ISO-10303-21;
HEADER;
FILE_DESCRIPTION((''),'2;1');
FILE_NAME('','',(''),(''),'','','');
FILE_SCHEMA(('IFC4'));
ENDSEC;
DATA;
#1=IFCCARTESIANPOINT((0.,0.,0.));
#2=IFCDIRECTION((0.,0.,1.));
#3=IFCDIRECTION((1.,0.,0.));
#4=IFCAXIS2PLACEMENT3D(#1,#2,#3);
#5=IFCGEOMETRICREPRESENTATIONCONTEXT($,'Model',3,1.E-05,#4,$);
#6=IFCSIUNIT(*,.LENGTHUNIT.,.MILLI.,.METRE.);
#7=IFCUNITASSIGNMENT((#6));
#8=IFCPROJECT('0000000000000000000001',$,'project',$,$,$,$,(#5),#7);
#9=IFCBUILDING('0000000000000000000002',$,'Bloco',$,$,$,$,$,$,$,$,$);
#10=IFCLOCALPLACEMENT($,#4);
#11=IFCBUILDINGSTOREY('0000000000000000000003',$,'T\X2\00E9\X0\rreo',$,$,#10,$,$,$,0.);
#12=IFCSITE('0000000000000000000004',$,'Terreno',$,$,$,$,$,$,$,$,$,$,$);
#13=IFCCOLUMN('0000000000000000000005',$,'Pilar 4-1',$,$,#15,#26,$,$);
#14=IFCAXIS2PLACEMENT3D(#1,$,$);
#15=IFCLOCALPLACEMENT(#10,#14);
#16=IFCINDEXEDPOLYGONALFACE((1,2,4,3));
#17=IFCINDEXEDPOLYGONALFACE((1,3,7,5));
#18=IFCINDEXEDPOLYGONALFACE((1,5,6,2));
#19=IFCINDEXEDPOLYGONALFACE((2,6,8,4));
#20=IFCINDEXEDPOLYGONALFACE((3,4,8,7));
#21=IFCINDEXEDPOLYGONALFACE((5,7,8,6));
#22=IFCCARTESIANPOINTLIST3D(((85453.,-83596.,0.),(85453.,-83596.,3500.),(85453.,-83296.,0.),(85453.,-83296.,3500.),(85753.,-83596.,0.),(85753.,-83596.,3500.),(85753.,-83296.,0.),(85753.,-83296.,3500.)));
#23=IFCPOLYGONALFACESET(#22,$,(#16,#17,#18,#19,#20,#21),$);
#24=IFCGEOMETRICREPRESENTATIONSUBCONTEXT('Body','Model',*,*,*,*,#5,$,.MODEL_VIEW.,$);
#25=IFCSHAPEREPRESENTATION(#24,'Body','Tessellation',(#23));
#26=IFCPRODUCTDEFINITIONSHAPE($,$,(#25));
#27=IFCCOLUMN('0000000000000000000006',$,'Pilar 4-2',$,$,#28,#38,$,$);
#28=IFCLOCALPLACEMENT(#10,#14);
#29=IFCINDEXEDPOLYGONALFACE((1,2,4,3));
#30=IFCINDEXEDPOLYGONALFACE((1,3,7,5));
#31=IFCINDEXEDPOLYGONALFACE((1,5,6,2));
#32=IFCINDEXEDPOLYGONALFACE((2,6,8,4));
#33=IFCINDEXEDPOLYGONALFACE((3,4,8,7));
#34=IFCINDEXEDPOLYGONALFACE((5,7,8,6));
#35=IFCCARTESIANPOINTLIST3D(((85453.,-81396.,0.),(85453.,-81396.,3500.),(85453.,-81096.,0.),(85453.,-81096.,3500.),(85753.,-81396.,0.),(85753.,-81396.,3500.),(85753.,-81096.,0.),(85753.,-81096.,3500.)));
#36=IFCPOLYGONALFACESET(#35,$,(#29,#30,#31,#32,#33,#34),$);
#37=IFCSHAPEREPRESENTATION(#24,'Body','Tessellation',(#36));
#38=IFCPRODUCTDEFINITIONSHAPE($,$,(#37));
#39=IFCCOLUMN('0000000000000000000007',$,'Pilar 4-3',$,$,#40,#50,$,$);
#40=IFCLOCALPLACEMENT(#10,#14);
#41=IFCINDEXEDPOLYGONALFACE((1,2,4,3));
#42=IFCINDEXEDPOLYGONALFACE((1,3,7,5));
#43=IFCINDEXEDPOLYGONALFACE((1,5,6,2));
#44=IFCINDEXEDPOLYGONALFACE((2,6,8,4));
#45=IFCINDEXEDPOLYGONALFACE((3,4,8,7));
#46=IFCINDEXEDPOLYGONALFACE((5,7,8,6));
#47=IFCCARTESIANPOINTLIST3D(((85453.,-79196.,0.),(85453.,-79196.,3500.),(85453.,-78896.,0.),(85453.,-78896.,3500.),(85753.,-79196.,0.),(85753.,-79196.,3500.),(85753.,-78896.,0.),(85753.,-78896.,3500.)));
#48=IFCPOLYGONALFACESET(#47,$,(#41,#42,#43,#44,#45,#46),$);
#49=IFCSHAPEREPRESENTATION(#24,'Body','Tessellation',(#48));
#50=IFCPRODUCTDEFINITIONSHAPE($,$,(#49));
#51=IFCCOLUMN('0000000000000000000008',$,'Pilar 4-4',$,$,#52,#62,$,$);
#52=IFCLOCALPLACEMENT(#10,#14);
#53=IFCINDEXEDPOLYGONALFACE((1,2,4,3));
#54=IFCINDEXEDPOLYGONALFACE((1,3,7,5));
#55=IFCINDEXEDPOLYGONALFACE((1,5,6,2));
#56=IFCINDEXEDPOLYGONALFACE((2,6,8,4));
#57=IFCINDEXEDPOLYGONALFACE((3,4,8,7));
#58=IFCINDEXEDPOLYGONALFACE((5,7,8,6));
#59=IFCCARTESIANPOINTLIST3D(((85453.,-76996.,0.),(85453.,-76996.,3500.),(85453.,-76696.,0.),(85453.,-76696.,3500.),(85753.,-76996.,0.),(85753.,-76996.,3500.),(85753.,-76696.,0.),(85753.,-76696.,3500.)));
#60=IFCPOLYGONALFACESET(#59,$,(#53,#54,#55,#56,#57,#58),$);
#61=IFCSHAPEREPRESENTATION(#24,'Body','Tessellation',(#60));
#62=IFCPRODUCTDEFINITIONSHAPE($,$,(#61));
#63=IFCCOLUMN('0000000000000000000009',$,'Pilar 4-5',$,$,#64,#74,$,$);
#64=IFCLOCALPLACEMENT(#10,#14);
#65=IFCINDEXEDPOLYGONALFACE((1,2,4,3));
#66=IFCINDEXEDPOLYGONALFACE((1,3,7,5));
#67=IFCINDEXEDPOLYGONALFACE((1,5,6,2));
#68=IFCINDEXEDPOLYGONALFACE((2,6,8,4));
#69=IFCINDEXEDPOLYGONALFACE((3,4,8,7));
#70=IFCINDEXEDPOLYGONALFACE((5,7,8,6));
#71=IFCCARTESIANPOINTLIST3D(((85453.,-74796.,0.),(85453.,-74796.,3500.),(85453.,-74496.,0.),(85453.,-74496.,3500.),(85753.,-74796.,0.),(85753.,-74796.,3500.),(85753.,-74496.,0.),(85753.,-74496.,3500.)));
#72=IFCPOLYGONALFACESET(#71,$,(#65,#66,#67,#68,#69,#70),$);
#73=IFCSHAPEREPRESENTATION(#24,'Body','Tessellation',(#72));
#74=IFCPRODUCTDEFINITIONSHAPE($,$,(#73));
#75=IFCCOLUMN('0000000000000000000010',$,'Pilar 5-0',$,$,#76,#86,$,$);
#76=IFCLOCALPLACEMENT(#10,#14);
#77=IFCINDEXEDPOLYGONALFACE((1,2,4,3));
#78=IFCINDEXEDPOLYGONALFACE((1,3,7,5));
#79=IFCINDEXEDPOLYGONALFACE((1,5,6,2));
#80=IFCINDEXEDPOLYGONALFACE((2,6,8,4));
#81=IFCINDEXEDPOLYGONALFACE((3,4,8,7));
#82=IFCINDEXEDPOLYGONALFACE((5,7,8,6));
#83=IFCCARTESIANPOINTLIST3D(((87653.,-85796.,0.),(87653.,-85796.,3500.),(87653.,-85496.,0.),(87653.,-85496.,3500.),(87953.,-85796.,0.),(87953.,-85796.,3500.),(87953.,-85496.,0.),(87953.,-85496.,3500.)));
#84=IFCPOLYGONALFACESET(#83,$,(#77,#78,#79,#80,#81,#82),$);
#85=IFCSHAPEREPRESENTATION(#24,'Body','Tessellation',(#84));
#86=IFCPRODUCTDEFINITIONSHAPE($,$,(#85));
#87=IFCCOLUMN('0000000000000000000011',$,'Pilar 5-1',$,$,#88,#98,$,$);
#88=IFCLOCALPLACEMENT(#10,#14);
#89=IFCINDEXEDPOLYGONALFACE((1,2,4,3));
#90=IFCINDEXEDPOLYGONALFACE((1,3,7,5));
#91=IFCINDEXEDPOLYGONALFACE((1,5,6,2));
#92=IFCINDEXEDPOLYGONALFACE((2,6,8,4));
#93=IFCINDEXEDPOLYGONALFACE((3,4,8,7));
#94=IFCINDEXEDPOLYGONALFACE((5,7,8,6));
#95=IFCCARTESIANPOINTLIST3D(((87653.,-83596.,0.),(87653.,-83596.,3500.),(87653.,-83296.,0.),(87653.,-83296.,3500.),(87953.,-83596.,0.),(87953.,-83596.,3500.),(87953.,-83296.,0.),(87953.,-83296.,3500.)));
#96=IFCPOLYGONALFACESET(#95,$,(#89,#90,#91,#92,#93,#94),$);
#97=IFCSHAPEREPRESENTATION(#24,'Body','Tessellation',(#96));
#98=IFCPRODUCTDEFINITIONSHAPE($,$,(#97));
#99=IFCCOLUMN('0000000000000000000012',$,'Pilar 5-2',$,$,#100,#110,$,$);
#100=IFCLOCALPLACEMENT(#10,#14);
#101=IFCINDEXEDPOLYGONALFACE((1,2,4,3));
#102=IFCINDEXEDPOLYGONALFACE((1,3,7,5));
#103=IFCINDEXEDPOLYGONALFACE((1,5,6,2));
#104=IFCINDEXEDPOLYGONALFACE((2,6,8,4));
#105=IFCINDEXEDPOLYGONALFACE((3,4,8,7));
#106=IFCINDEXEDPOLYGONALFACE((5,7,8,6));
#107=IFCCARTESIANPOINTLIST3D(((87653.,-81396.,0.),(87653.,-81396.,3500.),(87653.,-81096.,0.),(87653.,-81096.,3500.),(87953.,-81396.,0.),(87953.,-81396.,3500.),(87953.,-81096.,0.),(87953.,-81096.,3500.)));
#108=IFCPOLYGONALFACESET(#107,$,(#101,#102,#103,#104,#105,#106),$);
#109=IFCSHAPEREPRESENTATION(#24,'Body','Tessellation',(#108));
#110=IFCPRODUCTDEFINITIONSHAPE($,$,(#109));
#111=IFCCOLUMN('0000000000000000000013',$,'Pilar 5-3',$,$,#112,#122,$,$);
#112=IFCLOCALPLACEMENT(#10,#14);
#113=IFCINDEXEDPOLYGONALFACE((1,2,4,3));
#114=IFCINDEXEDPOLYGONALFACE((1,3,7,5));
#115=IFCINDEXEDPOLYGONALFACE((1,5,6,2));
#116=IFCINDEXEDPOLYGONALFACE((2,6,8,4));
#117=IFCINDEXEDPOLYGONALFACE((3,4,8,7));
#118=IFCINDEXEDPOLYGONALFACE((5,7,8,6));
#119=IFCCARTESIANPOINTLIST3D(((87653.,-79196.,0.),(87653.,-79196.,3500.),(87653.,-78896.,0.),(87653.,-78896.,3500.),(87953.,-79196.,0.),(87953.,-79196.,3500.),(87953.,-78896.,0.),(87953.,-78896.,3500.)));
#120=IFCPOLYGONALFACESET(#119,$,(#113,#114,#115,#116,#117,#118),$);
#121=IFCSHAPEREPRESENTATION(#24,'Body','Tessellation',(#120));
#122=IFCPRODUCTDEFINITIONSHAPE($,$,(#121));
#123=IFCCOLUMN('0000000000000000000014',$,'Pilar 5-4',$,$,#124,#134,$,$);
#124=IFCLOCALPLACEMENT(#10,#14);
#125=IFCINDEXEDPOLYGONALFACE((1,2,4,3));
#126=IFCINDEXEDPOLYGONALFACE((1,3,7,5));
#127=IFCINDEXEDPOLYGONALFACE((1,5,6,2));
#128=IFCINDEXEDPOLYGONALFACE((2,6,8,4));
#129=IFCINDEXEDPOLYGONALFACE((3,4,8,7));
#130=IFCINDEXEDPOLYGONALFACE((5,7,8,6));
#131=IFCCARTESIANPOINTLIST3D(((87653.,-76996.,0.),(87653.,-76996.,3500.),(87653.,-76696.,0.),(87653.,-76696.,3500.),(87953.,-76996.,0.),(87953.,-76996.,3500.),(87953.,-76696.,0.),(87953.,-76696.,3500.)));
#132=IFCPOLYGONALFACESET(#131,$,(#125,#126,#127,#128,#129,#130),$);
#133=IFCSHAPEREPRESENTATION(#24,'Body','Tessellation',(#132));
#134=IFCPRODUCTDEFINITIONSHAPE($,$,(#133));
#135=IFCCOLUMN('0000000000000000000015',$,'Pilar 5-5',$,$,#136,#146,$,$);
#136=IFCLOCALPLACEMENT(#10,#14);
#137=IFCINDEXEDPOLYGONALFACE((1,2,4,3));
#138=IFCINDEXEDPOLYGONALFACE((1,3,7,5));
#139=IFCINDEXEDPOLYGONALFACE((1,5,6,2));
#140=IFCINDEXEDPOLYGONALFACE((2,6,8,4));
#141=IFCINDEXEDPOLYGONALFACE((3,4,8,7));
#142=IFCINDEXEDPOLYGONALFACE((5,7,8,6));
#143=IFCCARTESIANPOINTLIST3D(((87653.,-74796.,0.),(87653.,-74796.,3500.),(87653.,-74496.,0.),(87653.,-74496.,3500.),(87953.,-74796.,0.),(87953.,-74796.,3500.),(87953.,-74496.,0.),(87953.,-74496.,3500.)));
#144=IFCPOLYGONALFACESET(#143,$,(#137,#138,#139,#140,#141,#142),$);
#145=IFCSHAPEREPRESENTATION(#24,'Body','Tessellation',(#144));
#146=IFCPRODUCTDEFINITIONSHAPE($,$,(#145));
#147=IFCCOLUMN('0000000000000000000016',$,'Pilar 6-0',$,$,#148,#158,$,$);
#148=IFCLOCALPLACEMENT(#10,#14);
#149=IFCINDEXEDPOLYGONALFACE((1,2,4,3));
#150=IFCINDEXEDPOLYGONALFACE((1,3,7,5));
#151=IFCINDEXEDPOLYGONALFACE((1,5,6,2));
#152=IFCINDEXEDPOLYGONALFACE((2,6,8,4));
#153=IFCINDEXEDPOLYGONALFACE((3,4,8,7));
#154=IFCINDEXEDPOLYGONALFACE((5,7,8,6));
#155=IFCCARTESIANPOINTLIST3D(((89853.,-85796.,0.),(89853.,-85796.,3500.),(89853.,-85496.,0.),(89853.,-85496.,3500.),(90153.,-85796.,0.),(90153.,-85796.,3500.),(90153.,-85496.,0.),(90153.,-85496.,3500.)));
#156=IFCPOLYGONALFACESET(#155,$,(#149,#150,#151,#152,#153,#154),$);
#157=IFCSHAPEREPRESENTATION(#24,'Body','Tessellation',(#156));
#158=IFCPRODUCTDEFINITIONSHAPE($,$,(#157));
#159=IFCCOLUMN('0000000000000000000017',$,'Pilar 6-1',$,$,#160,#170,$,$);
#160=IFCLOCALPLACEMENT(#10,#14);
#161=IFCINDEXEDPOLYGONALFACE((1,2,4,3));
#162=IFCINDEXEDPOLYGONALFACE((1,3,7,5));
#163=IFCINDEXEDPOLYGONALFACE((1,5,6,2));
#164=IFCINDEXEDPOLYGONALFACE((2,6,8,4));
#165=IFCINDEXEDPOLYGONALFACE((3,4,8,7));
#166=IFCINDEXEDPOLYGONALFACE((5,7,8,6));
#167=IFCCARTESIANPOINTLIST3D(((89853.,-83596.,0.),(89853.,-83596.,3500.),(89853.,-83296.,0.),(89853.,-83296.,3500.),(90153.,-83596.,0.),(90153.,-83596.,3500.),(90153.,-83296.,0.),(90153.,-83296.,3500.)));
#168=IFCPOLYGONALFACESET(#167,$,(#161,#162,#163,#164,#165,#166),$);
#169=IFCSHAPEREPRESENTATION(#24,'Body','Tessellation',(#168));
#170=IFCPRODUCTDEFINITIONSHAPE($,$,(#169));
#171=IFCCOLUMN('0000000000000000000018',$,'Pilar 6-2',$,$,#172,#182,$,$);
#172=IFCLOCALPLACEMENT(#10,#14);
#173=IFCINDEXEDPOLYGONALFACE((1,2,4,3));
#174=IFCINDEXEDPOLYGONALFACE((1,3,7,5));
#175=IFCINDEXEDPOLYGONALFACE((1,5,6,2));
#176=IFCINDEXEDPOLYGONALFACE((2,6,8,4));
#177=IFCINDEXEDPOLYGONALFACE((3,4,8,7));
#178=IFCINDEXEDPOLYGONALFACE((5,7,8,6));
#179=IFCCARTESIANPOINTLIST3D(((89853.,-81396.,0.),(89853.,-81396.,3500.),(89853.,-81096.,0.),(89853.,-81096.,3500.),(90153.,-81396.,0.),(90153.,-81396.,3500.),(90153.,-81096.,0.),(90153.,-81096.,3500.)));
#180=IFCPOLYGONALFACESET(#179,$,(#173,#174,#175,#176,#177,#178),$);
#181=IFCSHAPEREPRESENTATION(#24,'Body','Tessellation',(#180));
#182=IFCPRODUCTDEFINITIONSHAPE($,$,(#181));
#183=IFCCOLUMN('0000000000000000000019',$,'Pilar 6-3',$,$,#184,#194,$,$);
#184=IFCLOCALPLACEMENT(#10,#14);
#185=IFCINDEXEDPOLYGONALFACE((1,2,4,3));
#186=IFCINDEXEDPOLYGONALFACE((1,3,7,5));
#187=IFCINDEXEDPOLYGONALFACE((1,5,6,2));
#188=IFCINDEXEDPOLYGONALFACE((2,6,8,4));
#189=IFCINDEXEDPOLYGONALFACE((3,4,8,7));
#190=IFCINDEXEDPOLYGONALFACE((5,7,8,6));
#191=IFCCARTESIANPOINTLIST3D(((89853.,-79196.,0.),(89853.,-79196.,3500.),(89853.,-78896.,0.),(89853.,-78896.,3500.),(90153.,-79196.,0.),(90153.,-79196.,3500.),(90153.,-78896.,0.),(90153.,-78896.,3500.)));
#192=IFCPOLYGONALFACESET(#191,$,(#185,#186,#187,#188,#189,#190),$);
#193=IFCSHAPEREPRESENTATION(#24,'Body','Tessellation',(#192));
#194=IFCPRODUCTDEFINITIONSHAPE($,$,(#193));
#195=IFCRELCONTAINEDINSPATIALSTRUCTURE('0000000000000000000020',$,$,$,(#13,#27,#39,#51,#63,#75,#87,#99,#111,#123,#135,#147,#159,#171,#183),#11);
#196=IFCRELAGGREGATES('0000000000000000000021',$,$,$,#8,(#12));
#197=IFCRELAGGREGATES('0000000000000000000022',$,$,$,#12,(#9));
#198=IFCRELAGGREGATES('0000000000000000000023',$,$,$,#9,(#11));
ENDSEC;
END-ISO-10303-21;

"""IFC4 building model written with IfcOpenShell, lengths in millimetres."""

from ifc_helpers import new_model, si_unit, origin, origin_with_axes, place, context, subcontext, project, spatial, polyline, outline, extrude, element, save


model = new_model("IFC4")

# Units and contexts
model_context = context("Model", 3, precision=1e-05, world=origin_with_axes())
body_context = subcontext(model_context, "Body", "Model", "MODEL_VIEW")
ifc_project = project(units=[si_unit("LENGTHUNIT", "METRE", prefix="MILLI")], contexts=[model_context])

# Site, building, storey
site = spatial("IfcSite", under=ifc_project, Name="Terreno")
building = spatial("IfcBuilding", under=site, Name="Bloco")
storey_placement = place(None, origin_with_axes())
storey = spatial("IfcBuildingStorey", under=building, at=storey_placement, Name="Térreo", Elevation=0.0)

# Columns
column_1_placement = place(storey_placement, origin_with_axes())
element("IfcColumn", 1, at=column_1_placement, inside=storey, Name="Pilar 4-1", context=body_context, shape_type="SweptSolid", body=[
    extrude(outline(polyline([(85453.0, -83596.0), (85753.0, -83596.0), (85753.0, -83296.0), (85453.0, -83296.0), (85453.0, -83596.0)])), origin(), (0.0, 0.0, 1.0), 3500.0),
])
column_2_placement = place(storey_placement, origin_with_axes())
element("IfcColumn", 2, at=column_2_placement, inside=storey, Name="Pilar 4-2", context=body_context, shape_type="SweptSolid", body=[
    extrude(outline(polyline([(85453.0, -81396.0), (85753.0, -81396.0), (85753.0, -81096.0), (85453.0, -81096.0), (85453.0, -81396.0)])), origin(), (0.0, 0.0, 1.0), 3500.0),
])
column_3_placement = place(storey_placement, origin_with_axes())
element("IfcColumn", 3, at=column_3_placement, inside=storey, Name="Pilar 4-3", context=body_context, shape_type="SweptSolid", body=[
    extrude(outline(polyline([(85453.0, -79196.0), (85753.0, -79196.0), (85753.0, -78896.0), (85453.0, -78896.0), (85453.0, -79196.0)])), origin(), (0.0, 0.0, 1.0), 3500.0),
])
column_4_placement = place(storey_placement, origin_with_axes())
element("IfcColumn", 4, at=column_4_placement, inside=storey, Name="Pilar 4-4", context=body_context, shape_type="SweptSolid", body=[
    extrude(outline(polyline([(85453.0, -76996.0), (85753.0, -76996.0), (85753.0, -76696.0), (85453.0, -76696.0), (85453.0, -76996.0)])), origin(), (0.0, 0.0, 1.0), 3500.0),
])
column_5_placement = place(storey_placement, origin_with_axes())
element("IfcColumn", 5, at=column_5_placement, inside=storey, Name="Pilar 4-5", context=body_context, shape_type="SweptSolid", body=[
    extrude(outline(polyline([(85453.0, -74796.0), (85753.0, -74796.0), (85753.0, -74496.0), (85453.0, -74496.0), (85453.0, -74796.0)])), origin(), (0.0, 0.0, 1.0), 3500.0),
])
column_6_placement = place(storey_placement, origin_with_axes())
element("IfcColumn", 6, at=column_6_placement, inside=storey, Name="Pilar 5-0", context=body_context, shape_type="SweptSolid", body=[
    extrude(outline(polyline([(87653.0, -85796.0), (87953.0, -85796.0), (87953.0, -85496.0), (87653.0, -85496.0), (87653.0, -85796.0)])), origin(), (0.0, 0.0, 1.0), 3500.0),
])
column_7_placement = place(storey_placement, origin_with_axes())
element("IfcColumn", 7, at=column_7_placement, inside=storey, Name="Pilar 5-1", context=body_context, shape_type="SweptSolid", body=[
    extrude(outline(polyline([(87653.0, -83596.0), (87953.0, -83596.0), (87953.0, -83296.0), (87653.0, -83296.0), (87653.0, -83596.0)])), origin(), (0.0, 0.0, 1.0), 3500.0),
])
column_8_placement = place(storey_placement, origin_with_axes())
element("IfcColumn", 8, at=column_8_placement, inside=storey, Name="Pilar 5-2", context=body_context, shape_type="SweptSolid", body=[
    extrude(outline(polyline([(87653.0, -81396.0), (87953.0, -81396.0), (87953.0, -81096.0), (87653.0, -81096.0), (87653.0, -81396.0)])), origin(), (0.0, 0.0, 1.0), 3500.0),
])
column_9_placement = place(storey_placement, origin_with_axes())
element("IfcColumn", 9, at=column_9_placement, inside=storey, Name="Pilar 5-3", context=body_context, shape_type="SweptSolid", body=[
    extrude(outline(polyline([(87653.0, -79196.0), (87953.0, -79196.0), (87953.0, -78896.0), (87653.0, -78896.0), (87653.0, -79196.0)])), origin(), (0.0, 0.0, 1.0), 3500.0),
])
column_10_placement = place(storey_placement, origin_with_axes())
element("IfcColumn", 10, at=column_10_placement, inside=storey, Name="Pilar 5-4", context=body_context, shape_type="SweptSolid", body=[
    extrude(outline(polyline([(87653.0, -76996.0), (87953.0, -76996.0), (87953.0, -76696.0), (87653.0, -76696.0), (87653.0, -76996.0)])), origin(), (0.0, 0.0, 1.0), 3500.0),
])
column_11_placement = place(storey_placement, origin_with_axes())
element("IfcColumn", 11, at=column_11_placement, inside=storey, Name="Pilar 5-5", context=body_context, shape_type="SweptSolid", body=[
    extrude(outline(polyline([(87653.0, -74796.0), (87953.0, -74796.0), (87953.0, -74496.0), (87653.0, -74496.0), (87653.0, -74796.0)])), origin(), (0.0, 0.0, 1.0), 3500.0),
])
column_12_placement = place(storey_placement, origin_with_axes())
element("IfcColumn", 12, at=column_12_placement, inside=storey, Name="Pilar 6-0", context=body_context, shape_type="SweptSolid", body=[
    extrude(outline(polyline([(89853.0, -85796.0), (90153.0, -85796.0), (90153.0, -85496.0), (89853.0, -85496.0), (89853.0, -85796.0)])), origin(), (0.0, 0.0, 1.0), 3500.0),
])
column_13_placement = place(storey_placement, origin_with_axes())
element("IfcColumn", 13, at=column_13_placement, inside=storey, Name="Pilar 6-1", context=body_context, shape_type="SweptSolid", body=[
    extrude(outline(polyline([(89853.0, -83596.0), (90153.0, -83596.0), (90153.0, -83296.0), (89853.0, -83296.0), (89853.0, -83596.0)])), origin(), (0.0, 0.0, 1.0), 3500.0),
])
column_14_placement = place(storey_placement, origin_with_axes())
element("IfcColumn", 14, at=column_14_placement, inside=storey, Name="Pilar 6-2", context=body_context, shape_type="SweptSolid", body=[
    extrude(outline(polyline([(89853.0, -81396.0), (90153.0, -81396.0), (90153.0, -81096.0), (89853.0, -81096.0), (89853.0, -81396.0)])), origin(), (0.0, 0.0, 1.0), 3500.0),
])
column_15_placement = place(storey_placement, origin_with_axes())
element("IfcColumn", 15, at=column_15_placement, inside=storey, Name="Pilar 6-3", context=body_context, shape_type="SweptSolid", body=[
    extrude(outline(polyline([(89853.0, -79196.0), (90153.0, -79196.0), (90153.0, -78896.0), (89853.0, -78896.0), (89853.0, -79196.0)])), origin(), (0.0, 0.0, 1.0), 3500.0),
])

save(model, "model.ifc")
